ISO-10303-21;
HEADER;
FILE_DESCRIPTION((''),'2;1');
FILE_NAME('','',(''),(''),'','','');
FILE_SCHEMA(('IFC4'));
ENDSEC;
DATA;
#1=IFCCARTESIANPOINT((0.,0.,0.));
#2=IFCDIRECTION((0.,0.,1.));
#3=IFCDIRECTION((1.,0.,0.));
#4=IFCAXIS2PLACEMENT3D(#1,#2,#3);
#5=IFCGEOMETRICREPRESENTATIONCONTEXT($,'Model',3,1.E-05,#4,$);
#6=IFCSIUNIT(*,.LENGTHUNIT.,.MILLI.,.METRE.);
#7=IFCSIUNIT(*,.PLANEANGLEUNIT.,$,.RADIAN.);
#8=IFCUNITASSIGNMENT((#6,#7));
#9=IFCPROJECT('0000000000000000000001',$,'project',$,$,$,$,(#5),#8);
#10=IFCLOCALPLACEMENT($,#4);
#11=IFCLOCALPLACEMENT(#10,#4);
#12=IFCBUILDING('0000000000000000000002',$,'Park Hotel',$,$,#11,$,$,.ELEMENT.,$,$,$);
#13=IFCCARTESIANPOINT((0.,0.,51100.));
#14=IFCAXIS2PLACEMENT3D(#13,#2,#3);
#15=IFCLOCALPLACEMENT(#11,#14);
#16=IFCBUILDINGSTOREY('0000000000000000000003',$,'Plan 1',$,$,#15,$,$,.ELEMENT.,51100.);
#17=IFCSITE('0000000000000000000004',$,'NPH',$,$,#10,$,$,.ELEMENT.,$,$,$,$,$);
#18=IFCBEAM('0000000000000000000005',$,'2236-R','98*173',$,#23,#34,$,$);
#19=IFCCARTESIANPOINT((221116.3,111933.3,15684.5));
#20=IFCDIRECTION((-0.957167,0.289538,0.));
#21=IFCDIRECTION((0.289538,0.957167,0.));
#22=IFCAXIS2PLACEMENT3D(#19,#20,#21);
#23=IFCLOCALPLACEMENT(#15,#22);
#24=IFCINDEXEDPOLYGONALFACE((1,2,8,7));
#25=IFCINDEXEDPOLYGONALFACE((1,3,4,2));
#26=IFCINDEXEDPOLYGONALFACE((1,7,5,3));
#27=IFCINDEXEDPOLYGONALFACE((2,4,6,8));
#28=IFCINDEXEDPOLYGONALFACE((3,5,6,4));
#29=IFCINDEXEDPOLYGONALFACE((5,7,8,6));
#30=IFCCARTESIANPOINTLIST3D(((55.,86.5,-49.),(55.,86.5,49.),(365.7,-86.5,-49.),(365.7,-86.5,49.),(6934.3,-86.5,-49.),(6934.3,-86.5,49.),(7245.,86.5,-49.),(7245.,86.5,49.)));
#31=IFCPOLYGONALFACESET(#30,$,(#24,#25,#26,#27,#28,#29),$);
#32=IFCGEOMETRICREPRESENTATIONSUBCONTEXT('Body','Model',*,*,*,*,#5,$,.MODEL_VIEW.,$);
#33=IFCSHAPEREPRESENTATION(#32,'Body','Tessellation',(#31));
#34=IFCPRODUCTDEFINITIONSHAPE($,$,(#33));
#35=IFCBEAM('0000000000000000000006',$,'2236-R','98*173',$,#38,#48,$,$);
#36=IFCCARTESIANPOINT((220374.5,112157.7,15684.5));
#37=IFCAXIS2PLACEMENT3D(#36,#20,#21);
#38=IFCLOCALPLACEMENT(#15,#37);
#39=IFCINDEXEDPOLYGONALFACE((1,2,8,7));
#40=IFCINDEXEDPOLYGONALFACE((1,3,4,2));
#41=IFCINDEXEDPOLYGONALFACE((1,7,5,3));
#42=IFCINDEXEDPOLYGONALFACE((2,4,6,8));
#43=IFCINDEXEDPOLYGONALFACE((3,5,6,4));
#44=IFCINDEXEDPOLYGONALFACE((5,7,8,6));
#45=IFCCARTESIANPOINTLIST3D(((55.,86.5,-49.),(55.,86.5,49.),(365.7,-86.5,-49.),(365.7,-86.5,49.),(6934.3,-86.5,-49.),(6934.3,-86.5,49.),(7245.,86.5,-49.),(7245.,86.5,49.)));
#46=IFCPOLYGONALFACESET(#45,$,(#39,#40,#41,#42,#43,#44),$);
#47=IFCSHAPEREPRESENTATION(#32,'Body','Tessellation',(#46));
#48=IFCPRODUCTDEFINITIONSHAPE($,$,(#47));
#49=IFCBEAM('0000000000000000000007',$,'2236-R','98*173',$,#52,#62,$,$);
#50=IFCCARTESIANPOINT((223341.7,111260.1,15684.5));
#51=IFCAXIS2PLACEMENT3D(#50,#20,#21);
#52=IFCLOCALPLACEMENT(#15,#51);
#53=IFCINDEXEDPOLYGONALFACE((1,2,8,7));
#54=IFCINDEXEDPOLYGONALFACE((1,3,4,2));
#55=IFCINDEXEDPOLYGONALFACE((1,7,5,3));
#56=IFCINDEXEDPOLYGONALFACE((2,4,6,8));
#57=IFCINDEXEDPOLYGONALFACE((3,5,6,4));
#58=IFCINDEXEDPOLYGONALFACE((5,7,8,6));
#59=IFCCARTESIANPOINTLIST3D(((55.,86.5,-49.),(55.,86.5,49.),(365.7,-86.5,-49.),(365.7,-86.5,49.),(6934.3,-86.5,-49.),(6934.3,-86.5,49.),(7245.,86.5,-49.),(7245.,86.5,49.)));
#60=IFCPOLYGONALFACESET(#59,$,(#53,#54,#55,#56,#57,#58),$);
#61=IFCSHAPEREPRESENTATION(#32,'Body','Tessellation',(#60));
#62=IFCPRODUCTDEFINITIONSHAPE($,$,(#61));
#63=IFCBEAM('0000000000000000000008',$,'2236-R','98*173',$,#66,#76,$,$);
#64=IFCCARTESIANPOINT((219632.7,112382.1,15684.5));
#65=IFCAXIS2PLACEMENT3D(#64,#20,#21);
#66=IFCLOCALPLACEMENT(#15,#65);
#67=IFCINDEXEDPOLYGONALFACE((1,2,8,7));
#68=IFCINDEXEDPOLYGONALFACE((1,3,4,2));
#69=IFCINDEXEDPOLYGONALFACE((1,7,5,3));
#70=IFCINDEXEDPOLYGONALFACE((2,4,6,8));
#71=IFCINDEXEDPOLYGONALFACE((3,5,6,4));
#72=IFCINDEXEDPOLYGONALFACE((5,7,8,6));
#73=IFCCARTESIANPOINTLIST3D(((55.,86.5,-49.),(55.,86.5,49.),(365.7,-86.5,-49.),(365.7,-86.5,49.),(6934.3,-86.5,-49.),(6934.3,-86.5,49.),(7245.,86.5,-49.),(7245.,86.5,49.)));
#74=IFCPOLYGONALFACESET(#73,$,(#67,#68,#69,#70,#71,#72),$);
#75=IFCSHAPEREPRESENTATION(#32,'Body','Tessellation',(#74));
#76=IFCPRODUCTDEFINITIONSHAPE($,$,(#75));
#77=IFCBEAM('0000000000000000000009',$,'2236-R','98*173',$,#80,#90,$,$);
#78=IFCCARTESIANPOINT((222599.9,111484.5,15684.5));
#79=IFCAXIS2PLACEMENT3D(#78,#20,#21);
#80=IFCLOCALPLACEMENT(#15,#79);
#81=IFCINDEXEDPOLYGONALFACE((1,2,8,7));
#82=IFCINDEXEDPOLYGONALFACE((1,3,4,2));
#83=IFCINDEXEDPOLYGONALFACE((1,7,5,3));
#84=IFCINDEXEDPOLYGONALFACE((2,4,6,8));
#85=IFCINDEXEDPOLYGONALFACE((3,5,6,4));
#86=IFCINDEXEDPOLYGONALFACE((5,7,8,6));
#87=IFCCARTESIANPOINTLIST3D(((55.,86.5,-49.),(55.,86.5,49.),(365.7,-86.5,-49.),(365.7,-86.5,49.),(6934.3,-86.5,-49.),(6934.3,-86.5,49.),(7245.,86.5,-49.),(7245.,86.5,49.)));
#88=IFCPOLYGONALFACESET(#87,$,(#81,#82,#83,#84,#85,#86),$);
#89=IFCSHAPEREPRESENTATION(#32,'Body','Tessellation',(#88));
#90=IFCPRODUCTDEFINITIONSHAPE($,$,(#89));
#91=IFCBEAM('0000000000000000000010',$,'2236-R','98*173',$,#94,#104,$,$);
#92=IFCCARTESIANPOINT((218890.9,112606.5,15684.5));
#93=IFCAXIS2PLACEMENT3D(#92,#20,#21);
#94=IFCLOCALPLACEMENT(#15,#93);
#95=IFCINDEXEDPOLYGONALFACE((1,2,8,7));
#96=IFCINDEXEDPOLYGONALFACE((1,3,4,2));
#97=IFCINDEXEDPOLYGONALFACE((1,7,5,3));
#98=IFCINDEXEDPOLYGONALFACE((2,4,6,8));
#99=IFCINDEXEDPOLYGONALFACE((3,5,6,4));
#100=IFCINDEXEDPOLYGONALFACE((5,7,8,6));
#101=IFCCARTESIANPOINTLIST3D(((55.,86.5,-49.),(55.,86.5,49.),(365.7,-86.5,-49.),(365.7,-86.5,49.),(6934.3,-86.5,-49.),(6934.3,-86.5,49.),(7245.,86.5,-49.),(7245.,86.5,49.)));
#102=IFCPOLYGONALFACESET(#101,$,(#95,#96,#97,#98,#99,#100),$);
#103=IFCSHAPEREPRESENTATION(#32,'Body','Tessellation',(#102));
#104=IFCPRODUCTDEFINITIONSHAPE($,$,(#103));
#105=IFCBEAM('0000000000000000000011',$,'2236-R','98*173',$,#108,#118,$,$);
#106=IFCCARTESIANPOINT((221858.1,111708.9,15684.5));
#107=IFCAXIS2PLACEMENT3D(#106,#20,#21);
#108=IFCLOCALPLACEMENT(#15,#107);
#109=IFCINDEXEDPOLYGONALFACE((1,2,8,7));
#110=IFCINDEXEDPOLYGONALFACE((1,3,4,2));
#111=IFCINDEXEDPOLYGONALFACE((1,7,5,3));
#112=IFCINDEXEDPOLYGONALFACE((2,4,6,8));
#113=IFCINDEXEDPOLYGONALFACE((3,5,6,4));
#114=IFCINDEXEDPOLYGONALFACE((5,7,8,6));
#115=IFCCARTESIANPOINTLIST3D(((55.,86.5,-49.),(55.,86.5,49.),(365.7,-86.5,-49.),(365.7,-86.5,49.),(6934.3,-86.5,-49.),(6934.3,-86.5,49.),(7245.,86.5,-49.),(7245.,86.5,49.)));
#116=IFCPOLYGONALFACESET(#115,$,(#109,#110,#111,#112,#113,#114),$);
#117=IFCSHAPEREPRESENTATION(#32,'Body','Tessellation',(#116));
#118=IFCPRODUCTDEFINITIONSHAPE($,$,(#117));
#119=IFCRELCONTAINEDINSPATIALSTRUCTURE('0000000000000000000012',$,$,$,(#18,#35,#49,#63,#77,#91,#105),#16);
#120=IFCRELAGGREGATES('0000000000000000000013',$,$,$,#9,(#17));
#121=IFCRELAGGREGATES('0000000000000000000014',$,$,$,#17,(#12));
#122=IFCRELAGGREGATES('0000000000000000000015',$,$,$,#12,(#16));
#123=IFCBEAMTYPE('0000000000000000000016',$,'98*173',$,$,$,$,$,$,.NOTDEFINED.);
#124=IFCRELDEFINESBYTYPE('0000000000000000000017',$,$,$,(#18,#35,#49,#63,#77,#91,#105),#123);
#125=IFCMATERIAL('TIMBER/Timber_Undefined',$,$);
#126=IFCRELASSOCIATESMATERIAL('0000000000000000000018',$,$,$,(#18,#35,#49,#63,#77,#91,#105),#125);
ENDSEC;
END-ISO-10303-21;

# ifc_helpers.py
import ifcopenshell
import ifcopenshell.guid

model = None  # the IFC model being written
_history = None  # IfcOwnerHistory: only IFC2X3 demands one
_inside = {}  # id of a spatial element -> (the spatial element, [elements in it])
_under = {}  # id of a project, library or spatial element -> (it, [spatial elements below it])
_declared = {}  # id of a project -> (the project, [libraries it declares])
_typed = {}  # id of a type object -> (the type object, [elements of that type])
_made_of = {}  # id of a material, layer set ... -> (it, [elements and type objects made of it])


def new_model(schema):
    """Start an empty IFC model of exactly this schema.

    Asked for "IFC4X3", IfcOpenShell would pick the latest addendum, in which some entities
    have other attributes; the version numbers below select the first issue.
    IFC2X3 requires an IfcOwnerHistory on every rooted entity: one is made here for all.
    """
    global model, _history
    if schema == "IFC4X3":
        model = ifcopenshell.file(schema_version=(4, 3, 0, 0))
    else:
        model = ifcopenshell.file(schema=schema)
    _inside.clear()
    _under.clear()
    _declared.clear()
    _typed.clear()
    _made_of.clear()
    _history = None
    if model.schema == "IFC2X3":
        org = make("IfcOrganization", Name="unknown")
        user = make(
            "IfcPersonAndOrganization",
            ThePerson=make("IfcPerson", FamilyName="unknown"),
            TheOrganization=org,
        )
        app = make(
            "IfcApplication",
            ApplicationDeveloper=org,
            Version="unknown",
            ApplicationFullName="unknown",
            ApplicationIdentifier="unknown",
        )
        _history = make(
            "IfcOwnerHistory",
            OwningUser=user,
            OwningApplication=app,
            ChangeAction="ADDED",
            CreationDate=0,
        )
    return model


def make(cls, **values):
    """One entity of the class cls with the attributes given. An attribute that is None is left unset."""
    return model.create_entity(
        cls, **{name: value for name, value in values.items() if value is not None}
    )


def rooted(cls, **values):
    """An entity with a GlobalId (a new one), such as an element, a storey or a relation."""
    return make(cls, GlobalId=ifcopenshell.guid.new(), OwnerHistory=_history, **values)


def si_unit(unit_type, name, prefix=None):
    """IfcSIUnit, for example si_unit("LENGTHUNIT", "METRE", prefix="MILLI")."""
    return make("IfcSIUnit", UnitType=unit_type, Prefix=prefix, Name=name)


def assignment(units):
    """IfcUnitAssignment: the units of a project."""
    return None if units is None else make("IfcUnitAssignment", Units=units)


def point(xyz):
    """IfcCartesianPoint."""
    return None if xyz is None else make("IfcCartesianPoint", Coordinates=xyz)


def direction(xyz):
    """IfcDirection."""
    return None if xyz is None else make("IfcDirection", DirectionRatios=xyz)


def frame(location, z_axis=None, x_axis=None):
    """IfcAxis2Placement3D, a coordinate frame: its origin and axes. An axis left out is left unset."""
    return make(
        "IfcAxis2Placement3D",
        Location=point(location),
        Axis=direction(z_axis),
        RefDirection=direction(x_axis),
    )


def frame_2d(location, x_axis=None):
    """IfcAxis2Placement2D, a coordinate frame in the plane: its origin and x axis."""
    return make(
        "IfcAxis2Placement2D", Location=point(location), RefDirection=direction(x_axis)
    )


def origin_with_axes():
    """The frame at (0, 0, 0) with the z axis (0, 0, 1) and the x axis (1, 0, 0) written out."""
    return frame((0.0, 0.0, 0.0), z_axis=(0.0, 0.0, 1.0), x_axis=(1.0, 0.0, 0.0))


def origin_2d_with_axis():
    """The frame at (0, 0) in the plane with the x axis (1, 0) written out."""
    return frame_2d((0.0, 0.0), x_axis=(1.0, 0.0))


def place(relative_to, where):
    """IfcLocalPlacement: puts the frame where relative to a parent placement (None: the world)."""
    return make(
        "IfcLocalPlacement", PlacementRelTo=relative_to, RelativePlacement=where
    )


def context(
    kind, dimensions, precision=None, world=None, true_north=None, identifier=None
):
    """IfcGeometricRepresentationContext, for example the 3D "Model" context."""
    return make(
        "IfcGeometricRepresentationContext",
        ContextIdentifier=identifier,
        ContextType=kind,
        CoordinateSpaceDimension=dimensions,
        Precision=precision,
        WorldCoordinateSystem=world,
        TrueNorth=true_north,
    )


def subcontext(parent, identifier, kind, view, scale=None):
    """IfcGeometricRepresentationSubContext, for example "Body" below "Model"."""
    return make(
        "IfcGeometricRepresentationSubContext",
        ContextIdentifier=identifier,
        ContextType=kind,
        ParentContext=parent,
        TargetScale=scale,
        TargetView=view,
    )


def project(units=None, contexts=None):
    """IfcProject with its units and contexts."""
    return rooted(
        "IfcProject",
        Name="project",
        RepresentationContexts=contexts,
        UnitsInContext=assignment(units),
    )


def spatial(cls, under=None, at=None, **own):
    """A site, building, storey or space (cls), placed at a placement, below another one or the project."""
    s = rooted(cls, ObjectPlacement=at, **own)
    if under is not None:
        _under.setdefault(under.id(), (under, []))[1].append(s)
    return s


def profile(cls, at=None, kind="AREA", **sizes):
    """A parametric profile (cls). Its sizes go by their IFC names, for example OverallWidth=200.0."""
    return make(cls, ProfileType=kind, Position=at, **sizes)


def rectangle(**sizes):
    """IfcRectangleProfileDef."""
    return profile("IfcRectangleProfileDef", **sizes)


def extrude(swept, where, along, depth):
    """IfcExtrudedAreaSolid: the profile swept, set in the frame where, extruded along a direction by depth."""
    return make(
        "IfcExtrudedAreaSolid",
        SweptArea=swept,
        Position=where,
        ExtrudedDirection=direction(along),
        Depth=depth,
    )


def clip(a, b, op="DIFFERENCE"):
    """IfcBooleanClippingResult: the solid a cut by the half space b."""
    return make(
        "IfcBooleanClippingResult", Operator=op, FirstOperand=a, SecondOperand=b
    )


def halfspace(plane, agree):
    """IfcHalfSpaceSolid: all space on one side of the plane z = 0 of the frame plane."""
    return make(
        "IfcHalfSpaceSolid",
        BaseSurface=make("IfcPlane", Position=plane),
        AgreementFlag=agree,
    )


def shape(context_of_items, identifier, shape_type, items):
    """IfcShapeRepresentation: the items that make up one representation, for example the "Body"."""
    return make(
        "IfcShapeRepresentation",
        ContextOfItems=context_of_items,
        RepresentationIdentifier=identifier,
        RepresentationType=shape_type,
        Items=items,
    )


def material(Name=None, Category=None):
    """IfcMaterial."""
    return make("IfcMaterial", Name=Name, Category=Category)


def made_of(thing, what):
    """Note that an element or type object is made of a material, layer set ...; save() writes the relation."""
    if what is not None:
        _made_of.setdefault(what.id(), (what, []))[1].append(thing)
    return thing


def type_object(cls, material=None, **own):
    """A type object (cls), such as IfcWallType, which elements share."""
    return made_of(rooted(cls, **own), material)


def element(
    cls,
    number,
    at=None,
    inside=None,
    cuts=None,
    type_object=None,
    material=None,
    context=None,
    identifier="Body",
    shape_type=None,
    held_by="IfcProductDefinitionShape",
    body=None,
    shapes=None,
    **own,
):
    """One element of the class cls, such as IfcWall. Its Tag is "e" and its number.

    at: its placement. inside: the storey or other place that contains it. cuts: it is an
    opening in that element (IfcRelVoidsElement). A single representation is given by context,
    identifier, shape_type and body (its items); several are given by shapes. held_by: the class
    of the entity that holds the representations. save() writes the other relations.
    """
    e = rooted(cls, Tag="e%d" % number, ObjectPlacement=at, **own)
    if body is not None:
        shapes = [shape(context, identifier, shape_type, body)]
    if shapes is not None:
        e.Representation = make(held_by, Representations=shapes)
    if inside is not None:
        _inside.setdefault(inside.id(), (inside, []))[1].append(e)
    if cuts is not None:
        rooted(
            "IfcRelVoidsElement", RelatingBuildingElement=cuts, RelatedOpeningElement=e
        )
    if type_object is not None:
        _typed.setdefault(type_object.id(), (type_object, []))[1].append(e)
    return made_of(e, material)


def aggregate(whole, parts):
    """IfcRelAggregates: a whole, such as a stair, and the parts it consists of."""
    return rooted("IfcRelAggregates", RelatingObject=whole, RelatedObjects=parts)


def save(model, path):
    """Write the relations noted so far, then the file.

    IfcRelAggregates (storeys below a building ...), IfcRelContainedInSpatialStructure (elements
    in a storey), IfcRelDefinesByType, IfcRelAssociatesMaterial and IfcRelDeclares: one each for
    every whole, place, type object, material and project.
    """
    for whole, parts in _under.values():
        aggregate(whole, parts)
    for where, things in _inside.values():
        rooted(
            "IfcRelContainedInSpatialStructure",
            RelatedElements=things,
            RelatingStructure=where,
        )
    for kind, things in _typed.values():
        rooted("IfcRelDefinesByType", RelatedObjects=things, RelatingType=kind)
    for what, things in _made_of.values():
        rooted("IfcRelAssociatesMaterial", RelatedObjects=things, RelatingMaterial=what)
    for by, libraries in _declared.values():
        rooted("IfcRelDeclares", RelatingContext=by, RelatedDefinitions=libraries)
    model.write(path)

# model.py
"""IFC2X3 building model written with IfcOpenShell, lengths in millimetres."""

from ifc_helpers import new_model, si_unit, frame, origin_with_axes, origin_2d_with_axis, place, context, subcontext, project, spatial, rectangle, extrude, clip, halfspace, material, type_object, element, save


model = new_model("IFC2X3")

# Units and contexts
model_context = context("Model", 3, precision=1e-05, world=origin_with_axes())
body_context = subcontext(model_context, "Body", "Model", "MODEL_VIEW")
ifc_project = project(units=[si_unit("LENGTHUNIT", "METRE", prefix="MILLI"), si_unit("PLANEANGLEUNIT", "RADIAN")], contexts=[model_context])

# Site, building, storey
site_placement = place(None, origin_with_axes())
site = spatial("IfcSite", under=ifc_project, at=site_placement, Name="NPH", CompositionType="ELEMENT")
building_placement = place(site_placement, origin_with_axes())
building = spatial("IfcBuilding", under=site, at=building_placement, Name="Park Hotel", CompositionType="ELEMENT")
storey_placement = place(building_placement, frame((0.0, 0.0, 51100.0), z_axis=(0.0, 0.0, 1.0), x_axis=(1.0, 0.0, 0.0)))
storey = spatial("IfcBuildingStorey", under=building, at=storey_placement, Name="Plan 1", CompositionType="ELEMENT", Elevation=51100.0)

# Shared definitions
ifc_material_1 = material(Name="TIMBER/Timber_Undefined")

# Beams
beam_type_1 = type_object("IfcBeamType", Name="98*173", PredefinedType="NOTDEFINED")
for number, where, z_axis, x_axis, name in (
    (1, (221116.3, 111933.3, 15684.5), (-0.957167, 0.289538, 0.0), (0.289538, 0.957167, 0.0), "2236-R"),
    (2, (220374.5, 112157.7, 15684.5), (-0.957167, 0.289538, 0.0), (0.289538, 0.957167, 0.0), "2236-R"),
    (3, (223341.7, 111260.1, 15684.5), (-0.957167, 0.289538, 0.0), (0.289538, 0.957167, 0.0), "2236-R"),
    (4, (219632.7, 112382.1, 15684.5), (-0.957167, 0.289538, 0.0), (0.289538, 0.957167, 0.0), "2236-R"),
    (5, (222599.9, 111484.5, 15684.5), (-0.957167, 0.289538, 0.0), (0.289538, 0.957167, 0.0), "2236-R"),
    (6, (218890.9, 112606.5, 15684.5), (-0.957167, 0.289538, 0.0), (0.289538, 0.957167, 0.0), "2236-R"),
    (7, (221858.1, 111708.9, 15684.5), (-0.957167, 0.289538, 0.0), (0.289538, 0.957167, 0.0), "2236-R"),
):
    element("IfcBeam", number, at=place(storey_placement, frame(where, z_axis=z_axis, x_axis=x_axis)), inside=storey, type_object=beam_type_1, material=ifc_material_1, Name=name, Description="98*173", context=body_context, shape_type="Clipping", body=[
        clip(clip(extrude(rectangle(XDim=173.0, YDim=98.0, at=origin_2d_with_axis()), frame((7270.0, 0.0, 0.0), z_axis=(-1.0, 0.0, 0.0), x_axis=(0.0, -1.0, 0.0)), (0.0, 0.0, 1.0), 7270.0), halfspace(frame((55.0, 86.5, -49.0), z_axis=(-0.486528, -0.873665, 0.0), x_axis=(0.0, 0.0, 1.0)), False)), halfspace(frame((7245.0, 86.5, 49.0), z_axis=(0.486529, -0.873664, 0.0), x_axis=(0.0, 0.0, -1.0)), False)),
    ])

save(model, "model.ifc")
